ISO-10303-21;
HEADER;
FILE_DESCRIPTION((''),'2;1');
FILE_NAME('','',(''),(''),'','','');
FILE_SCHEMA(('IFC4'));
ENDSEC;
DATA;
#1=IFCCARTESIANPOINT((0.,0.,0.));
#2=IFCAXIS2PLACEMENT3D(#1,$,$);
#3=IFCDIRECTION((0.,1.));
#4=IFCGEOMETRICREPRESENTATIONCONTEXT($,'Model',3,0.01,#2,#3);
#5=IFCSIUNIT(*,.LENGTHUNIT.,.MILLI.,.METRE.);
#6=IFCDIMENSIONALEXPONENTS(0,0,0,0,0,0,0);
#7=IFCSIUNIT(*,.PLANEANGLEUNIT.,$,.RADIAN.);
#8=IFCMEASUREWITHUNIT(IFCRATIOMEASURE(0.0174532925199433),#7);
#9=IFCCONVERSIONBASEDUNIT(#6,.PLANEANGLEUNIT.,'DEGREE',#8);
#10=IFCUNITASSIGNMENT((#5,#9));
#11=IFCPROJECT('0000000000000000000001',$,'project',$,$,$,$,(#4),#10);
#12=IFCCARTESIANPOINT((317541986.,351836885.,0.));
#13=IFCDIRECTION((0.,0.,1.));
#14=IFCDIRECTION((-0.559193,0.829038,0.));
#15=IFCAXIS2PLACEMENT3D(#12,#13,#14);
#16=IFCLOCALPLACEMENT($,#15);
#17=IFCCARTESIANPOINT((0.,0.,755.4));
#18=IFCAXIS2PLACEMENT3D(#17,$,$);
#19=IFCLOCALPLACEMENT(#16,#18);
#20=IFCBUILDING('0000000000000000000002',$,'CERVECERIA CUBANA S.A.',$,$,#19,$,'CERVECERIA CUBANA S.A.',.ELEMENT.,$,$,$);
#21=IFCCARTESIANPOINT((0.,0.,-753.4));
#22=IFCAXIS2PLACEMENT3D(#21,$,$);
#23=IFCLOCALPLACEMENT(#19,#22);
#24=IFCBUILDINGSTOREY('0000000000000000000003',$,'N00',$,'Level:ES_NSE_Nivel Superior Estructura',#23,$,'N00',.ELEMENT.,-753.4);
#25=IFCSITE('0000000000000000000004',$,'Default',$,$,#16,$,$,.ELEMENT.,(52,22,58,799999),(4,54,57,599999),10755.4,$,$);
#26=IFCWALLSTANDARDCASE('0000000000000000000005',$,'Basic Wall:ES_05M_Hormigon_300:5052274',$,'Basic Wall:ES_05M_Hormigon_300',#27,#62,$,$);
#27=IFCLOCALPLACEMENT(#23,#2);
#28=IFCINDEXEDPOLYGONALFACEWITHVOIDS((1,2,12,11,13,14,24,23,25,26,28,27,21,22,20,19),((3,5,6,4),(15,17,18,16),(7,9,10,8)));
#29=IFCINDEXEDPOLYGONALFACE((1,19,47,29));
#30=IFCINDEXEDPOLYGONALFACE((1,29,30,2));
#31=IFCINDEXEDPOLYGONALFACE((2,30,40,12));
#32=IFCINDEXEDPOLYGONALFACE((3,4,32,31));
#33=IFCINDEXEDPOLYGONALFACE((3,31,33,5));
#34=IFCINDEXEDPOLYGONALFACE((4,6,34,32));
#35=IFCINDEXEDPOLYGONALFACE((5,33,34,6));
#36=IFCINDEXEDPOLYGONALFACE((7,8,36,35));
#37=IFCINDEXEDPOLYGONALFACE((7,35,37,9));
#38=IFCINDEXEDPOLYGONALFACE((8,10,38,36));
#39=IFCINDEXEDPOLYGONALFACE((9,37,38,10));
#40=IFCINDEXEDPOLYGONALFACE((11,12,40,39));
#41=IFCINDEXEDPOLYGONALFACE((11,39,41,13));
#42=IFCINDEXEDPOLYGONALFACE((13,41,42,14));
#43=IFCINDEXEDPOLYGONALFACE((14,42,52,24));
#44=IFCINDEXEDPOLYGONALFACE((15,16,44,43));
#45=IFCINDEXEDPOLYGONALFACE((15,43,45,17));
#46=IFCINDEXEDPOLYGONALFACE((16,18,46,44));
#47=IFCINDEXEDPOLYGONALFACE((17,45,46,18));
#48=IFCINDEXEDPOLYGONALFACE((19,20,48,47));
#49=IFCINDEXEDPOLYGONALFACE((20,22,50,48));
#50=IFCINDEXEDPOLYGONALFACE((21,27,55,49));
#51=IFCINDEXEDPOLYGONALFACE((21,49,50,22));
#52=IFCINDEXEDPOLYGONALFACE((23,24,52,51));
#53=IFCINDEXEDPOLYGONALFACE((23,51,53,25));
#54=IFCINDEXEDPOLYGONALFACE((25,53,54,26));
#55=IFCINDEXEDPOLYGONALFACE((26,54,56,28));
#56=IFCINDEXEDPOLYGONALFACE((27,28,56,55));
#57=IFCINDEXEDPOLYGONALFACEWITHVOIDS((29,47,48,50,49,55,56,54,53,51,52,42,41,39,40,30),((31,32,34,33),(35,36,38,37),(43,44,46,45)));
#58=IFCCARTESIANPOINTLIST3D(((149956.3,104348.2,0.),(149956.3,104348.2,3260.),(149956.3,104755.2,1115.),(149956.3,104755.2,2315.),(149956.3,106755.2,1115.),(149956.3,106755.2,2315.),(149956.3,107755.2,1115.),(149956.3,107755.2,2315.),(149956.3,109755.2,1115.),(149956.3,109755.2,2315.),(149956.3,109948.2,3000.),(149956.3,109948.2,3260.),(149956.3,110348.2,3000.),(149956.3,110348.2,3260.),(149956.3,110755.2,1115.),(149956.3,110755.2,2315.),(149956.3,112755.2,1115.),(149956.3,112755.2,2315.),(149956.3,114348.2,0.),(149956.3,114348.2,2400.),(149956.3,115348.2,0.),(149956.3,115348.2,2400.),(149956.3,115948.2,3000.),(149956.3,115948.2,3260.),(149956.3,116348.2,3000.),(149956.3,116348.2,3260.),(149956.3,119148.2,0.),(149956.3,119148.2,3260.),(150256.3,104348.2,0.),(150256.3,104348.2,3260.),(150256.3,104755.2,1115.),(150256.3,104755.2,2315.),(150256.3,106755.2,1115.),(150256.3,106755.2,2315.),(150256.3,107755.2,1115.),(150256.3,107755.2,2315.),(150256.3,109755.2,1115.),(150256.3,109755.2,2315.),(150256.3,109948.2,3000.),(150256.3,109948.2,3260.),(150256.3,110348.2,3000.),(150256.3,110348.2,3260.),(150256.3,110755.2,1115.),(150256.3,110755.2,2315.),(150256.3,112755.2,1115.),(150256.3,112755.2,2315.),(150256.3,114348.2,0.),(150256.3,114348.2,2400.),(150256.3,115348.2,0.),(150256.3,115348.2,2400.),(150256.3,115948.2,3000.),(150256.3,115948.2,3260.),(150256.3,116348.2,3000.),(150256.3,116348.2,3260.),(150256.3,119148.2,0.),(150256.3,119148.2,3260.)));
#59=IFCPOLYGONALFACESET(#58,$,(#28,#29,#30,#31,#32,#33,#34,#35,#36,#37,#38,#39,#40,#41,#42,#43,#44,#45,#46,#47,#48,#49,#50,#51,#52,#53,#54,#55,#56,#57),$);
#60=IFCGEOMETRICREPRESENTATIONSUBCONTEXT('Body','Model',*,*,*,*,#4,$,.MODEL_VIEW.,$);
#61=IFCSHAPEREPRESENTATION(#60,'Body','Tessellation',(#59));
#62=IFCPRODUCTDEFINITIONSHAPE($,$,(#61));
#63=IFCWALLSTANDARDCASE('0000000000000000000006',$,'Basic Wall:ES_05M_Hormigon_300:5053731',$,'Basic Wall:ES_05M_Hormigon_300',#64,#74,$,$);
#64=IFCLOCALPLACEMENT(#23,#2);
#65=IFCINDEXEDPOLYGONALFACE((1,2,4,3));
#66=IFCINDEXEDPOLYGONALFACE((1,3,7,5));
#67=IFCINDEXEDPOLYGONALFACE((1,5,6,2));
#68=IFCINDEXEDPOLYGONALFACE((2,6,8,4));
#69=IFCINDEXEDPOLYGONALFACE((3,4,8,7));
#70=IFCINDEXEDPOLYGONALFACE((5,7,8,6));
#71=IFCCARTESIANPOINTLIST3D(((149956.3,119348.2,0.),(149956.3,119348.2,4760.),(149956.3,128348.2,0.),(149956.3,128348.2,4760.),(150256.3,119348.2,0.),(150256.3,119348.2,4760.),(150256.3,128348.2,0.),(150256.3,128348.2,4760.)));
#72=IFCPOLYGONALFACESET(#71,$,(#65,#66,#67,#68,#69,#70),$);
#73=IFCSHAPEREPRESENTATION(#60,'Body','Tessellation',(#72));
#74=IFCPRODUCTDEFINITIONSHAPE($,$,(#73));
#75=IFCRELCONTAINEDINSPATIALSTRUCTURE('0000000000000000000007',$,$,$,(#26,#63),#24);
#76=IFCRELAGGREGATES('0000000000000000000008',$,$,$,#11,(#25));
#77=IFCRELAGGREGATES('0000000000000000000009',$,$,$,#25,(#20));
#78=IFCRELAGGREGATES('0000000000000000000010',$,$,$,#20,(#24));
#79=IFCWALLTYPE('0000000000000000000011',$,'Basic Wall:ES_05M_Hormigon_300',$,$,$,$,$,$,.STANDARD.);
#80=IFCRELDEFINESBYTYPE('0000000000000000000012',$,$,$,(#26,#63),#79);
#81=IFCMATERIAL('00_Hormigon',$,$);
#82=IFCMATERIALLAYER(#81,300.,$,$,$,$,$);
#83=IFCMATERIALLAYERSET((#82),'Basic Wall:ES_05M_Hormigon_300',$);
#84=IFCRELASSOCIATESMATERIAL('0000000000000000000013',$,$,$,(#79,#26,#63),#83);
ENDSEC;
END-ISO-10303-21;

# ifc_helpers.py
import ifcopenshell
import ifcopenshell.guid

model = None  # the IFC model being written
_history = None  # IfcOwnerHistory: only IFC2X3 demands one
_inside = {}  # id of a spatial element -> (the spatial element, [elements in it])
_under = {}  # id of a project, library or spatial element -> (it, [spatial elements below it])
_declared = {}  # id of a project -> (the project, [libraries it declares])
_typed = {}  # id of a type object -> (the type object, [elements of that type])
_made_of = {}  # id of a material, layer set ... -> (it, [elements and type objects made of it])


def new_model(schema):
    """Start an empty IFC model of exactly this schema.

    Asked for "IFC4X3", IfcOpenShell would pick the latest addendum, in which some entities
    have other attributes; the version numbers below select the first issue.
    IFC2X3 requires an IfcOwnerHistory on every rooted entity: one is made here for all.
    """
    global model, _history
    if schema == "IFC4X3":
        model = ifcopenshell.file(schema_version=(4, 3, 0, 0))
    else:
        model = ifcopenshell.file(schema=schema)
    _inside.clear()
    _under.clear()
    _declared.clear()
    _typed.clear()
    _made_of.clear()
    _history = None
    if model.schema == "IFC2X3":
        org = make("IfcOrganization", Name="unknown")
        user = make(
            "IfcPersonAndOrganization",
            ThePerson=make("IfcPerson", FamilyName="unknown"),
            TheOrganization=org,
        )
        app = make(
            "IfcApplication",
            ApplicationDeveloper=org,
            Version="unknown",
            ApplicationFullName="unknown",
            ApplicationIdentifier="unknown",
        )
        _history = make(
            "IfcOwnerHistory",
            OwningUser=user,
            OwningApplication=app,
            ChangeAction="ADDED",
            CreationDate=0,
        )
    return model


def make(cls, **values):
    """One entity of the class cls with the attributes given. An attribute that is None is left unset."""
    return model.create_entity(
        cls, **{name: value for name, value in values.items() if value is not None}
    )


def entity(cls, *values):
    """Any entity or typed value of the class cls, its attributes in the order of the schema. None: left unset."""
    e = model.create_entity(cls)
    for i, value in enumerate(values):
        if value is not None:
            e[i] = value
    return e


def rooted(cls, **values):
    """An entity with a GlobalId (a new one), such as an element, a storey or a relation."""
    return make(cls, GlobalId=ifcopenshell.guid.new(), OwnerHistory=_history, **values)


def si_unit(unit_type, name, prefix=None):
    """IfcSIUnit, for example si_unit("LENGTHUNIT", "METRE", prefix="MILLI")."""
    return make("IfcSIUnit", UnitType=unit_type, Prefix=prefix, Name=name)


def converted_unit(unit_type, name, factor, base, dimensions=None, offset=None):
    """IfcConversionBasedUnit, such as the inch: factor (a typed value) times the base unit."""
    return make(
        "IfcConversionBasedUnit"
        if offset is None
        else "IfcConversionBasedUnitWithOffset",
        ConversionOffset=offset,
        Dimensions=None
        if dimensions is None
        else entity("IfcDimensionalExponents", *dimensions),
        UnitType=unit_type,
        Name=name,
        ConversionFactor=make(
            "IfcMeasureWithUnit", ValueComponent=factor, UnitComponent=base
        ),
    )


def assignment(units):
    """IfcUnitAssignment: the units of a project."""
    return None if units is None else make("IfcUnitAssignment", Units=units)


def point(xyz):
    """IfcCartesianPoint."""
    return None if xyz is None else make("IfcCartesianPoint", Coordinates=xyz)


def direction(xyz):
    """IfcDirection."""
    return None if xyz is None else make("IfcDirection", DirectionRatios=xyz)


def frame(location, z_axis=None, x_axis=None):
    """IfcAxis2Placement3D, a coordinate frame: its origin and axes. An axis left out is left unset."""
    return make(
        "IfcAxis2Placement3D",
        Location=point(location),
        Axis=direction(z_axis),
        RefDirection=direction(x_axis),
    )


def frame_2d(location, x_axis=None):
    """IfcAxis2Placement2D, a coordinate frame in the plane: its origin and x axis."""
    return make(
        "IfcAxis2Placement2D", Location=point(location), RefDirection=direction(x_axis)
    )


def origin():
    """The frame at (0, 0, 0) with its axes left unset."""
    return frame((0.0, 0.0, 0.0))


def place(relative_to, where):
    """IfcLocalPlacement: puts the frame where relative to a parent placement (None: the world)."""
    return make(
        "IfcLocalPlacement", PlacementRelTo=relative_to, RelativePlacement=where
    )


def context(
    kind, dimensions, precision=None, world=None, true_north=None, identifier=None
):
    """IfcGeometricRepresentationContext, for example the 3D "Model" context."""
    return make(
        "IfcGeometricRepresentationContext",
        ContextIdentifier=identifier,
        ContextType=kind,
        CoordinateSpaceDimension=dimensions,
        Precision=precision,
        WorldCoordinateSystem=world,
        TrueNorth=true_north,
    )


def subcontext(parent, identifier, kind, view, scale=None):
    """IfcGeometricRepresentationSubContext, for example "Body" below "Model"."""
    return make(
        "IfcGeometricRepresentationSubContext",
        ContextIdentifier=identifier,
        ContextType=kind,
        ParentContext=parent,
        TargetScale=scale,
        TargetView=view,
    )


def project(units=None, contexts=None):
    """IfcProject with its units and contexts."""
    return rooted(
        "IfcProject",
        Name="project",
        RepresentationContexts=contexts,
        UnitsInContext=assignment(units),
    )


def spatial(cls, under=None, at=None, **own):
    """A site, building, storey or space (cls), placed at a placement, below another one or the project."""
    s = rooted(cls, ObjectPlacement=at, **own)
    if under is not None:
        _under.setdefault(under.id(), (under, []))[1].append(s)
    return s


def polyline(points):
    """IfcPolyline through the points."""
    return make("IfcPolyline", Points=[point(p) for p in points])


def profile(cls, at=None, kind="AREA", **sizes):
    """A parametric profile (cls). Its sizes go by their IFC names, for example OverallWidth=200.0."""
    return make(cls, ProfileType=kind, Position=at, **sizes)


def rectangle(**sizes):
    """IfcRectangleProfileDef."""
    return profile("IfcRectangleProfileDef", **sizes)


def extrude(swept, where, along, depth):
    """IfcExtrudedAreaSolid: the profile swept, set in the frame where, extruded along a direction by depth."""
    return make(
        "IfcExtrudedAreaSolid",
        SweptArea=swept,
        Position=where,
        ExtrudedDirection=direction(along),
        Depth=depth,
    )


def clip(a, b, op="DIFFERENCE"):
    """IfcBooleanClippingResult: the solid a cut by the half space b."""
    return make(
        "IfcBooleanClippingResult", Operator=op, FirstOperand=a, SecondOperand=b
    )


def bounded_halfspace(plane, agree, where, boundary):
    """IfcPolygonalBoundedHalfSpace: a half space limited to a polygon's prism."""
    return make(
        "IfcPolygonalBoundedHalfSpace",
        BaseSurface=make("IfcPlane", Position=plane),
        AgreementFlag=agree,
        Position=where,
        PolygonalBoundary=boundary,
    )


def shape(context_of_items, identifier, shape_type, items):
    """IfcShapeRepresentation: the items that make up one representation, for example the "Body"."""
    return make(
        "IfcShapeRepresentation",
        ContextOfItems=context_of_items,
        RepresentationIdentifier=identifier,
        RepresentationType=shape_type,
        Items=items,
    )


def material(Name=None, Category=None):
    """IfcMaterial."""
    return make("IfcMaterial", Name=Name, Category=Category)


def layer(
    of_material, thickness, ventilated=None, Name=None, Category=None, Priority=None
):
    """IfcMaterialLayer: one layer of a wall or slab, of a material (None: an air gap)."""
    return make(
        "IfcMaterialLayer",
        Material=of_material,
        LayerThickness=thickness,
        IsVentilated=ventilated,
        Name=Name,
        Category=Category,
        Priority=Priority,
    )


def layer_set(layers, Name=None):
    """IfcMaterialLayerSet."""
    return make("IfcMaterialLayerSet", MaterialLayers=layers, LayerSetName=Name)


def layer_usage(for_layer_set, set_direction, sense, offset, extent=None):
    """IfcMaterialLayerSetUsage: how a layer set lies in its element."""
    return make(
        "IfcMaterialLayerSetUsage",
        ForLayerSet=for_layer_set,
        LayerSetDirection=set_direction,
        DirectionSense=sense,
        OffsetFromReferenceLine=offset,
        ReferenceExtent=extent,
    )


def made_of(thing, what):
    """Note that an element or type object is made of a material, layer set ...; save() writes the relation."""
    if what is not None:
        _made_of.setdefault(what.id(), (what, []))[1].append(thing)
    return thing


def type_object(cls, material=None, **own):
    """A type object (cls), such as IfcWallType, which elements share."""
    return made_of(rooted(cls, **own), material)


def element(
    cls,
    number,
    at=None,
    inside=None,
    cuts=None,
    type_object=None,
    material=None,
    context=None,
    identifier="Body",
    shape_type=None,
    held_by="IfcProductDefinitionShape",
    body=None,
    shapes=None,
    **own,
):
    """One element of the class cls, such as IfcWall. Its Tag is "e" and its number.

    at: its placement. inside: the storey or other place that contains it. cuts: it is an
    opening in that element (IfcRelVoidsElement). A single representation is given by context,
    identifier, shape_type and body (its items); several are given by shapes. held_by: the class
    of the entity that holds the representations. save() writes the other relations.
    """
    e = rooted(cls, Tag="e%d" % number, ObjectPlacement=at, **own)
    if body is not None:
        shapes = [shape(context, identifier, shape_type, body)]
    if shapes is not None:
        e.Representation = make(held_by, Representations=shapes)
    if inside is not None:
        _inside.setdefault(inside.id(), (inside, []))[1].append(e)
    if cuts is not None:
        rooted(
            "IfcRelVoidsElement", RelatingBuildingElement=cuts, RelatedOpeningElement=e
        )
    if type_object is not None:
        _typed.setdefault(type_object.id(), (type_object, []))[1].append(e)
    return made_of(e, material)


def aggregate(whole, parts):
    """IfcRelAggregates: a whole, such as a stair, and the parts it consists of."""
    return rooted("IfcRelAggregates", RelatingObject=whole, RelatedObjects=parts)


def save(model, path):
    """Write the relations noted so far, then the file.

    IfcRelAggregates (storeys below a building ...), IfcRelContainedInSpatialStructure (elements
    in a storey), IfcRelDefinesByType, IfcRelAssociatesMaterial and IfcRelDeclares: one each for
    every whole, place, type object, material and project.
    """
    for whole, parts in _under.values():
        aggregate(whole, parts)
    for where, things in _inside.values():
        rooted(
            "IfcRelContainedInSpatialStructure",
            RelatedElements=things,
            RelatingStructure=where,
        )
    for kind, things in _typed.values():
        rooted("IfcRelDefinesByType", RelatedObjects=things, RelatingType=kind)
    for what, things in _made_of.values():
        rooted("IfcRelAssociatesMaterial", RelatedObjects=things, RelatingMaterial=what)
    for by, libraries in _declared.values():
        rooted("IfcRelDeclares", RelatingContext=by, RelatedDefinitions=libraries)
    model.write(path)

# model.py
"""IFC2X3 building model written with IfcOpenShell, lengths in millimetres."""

from ifc_helpers import new_model, entity, si_unit, converted_unit, direction, frame, frame_2d, origin, place, context, subcontext, project, spatial, polyline, rectangle, extrude, clip, bounded_halfspace, material, layer, layer_set, layer_usage, type_object, element, save


model = new_model("IFC2X3")

# Units and contexts
model_context = context("Model", 3, precision=0.01, world=origin(), true_north=direction((0.0, 1.0)))
body_context = subcontext(model_context, "Body", "Model", "MODEL_VIEW")
ifc_project = project(units=[si_unit("LENGTHUNIT", "METRE", prefix="MILLI"), converted_unit("PLANEANGLEUNIT", "DEGREE", entity("IfcRatioMeasure", 0.0174532925199433), si_unit("PLANEANGLEUNIT", "RADIAN"), dimensions=[0, 0, 0, 0, 0, 0, 0])], contexts=[model_context])

# Site, building, storey
site_placement = place(None, frame((317541986.0, 351836885.0, 0.0), z_axis=(0.0, 0.0, 1.0), x_axis=(-0.559193, 0.829038, 0.0)))
site = spatial("IfcSite", under=ifc_project, at=site_placement, Name="Default", CompositionType="ELEMENT", RefLatitude=(52, 22, 58, 799999), RefLongitude=(4, 54, 57, 599999), RefElevation=10755.4)
building_placement = place(site_placement, frame((0.0, 0.0, 755.4)))
building = spatial("IfcBuilding", under=site, at=building_placement, Name="CERVECERIA CUBANA S.A.", LongName="CERVECERIA CUBANA S.A.", CompositionType="ELEMENT")
storey_placement = place(building_placement, frame((0.0, 0.0, -753.4)))
storey = spatial("IfcBuildingStorey", under=building, at=storey_placement, Name="N00", ObjectType="Level:ES_NSE_Nivel Superior Estructura", LongName="N00", CompositionType="ELEMENT", Elevation=-753.4)

# Shared definitions
ifc_material = material(Name="00_Hormigon")

# Wall, openings
ifc_layer_1 = layer(ifc_material, 300.0)
ifc_layer_set_1 = layer_set([ifc_layer_1], Name="Basic Wall:ES_05M_Hormigon_300")
ifc_layer_usage_1 = layer_usage(ifc_layer_set_1, "AXIS2", "NEGATIVE", 150.0)
wall_type_1 = type_object("IfcWallType", Name="Basic Wall:ES_05M_Hormigon_300", PredefinedType="STANDARD", material=ifc_layer_set_1)
wall_1_placement = place(storey_placement, frame((150106.3, 119148.2, 0.0), z_axis=(0.0, 0.0, 1.0), x_axis=(0.0, -1.0, 0.0)))
wall_1 = element("IfcWallStandardCase", 1, at=wall_1_placement, inside=storey, type_object=wall_type_1, material=ifc_layer_usage_1, Name="Basic Wall:ES_05M_Hormigon_300:5052274", ObjectType="Basic Wall:ES_05M_Hormigon_300", context=body_context, shape_type="Clipping", body=[
    clip(clip(extrude(rectangle(XDim=14800.0, YDim=300.0, at=frame_2d((7400.0, 0.0), x_axis=(-1.0, 0.0))), origin(), (0.0, 0.0, 1.0), 3260.0), bounded_halfspace(frame((9200.0, -150.0, 3000.0), z_axis=(0.0, 0.0, -1.0), x_axis=(0.0, -1.0, 0.0)), True, frame((9200.0, -150.0, 3000.0), z_axis=(0.0, 0.0, -1.0), x_axis=(0.0, -1.0, 0.0)), polyline([(0.0, 0.0), (0.0, 400.0), (-300.0, 400.0), (-300.0, 0.0), (0.0, 0.0)]))), bounded_halfspace(frame((3200.0, -150.0, 3000.0), z_axis=(0.0, 0.0, -1.0), x_axis=(0.0, -1.0, 0.0)), True, frame((3200.0, -150.0, 3000.0), z_axis=(0.0, 0.0, -1.0), x_axis=(0.0, -1.0, 0.0)), polyline([(0.0, 0.0), (0.0, 400.0), (-300.0, 400.0), (-300.0, 0.0), (0.0, 0.0)]))),
])
opening_1_placement = place(wall_1_placement, frame((119148.2, -150106.3, 0.0), z_axis=(0.0, 0.0, 1.0), x_axis=(0.0, 1.0, 0.0)))
element("IfcOpeningElement", 2, at=opening_1_placement, cuts=wall_1, ObjectType="Opening", context=body_context, shape_type="SweptSolid", body=[
    extrude(rectangle(XDim=2400.0, YDim=1000.0, at=frame_2d((0.0, 0.0), x_axis=(0.0, 1.0))), frame((148432.3, 114848.2, 1200.0), z_axis=(1.0, 0.0, 0.0), x_axis=(0.0, -1.0, 0.0)), (0.0, 0.0, 1.0), 3048.0),
])
opening_2_placement = place(wall_1_placement, frame((119148.2, -150106.3, 0.0), z_axis=(0.0, 0.0, 1.0), x_axis=(0.0, 1.0, 0.0)))
element("IfcOpeningElement", 3, at=opening_2_placement, cuts=wall_1, ObjectType="Opening", context=body_context, shape_type="SweptSolid", body=[
    extrude(rectangle(XDim=1200.0, YDim=2000.0, at=frame_2d((0.0, 0.0), x_axis=(0.0, 1.0))), frame((148432.3, 105755.2, 1715.0), z_axis=(1.0, 0.0, 0.0), x_axis=(0.0, -1.0, 0.0)), (0.0, 0.0, 1.0), 3048.0),
])
opening_3_placement = place(wall_1_placement, frame((119148.2, -150106.3, 0.0), z_axis=(0.0, 0.0, 1.0), x_axis=(0.0, 1.0, 0.0)))
element("IfcOpeningElement", 4, at=opening_3_placement, cuts=wall_1, ObjectType="Opening", context=body_context, shape_type="SweptSolid", body=[
    extrude(rectangle(XDim=1200.0, YDim=2000.0, at=frame_2d((0.0, 0.0), x_axis=(0.0, 1.0))), frame((148432.3, 108755.2, 1715.0), z_axis=(1.0, 0.0, 0.0), x_axis=(0.0, -1.0, 0.0)), (0.0, 0.0, 1.0), 3048.0),
])
opening_4_placement = place(wall_1_placement, frame((119148.2, -150106.3, 0.0), z_axis=(0.0, 0.0, 1.0), x_axis=(0.0, 1.0, 0.0)))
element("IfcOpeningElement", 5, at=opening_4_placement, cuts=wall_1, ObjectType="Opening", context=body_context, shape_type="SweptSolid", body=[
    extrude(rectangle(XDim=1200.0, YDim=2000.0, at=frame_2d((0.0, 0.0), x_axis=(0.0, 1.0))), frame((148432.3, 111755.2, 1715.0), z_axis=(1.0, 0.0, 0.0), x_axis=(0.0, -1.0, 0.0)), (0.0, 0.0, 1.0), 3048.0),
])

# Wall
ifc_layer_usage_2 = layer_usage(ifc_layer_set_1, "AXIS2", "NEGATIVE", 150.0)
wall_2_placement = place(storey_placement, frame((150106.3, 128348.2, 0.0), z_axis=(0.0, 0.0, 1.0), x_axis=(0.0, -1.0, 0.0)))
element("IfcWallStandardCase", 6, at=wall_2_placement, inside=storey, type_object=wall_type_1, material=ifc_layer_usage_2, Name="Basic Wall:ES_05M_Hormigon_300:5053731", ObjectType="Basic Wall:ES_05M_Hormigon_300", context=body_context, shape_type="SweptSolid", body=[
    extrude(rectangle(XDim=9000.0, YDim=300.0, at=frame_2d((4500.0, 0.0), x_axis=(-1.0, 0.0))), origin(), (0.0, 0.0, 1.0), 4760.0),
])

save(model, "model.ifc")
